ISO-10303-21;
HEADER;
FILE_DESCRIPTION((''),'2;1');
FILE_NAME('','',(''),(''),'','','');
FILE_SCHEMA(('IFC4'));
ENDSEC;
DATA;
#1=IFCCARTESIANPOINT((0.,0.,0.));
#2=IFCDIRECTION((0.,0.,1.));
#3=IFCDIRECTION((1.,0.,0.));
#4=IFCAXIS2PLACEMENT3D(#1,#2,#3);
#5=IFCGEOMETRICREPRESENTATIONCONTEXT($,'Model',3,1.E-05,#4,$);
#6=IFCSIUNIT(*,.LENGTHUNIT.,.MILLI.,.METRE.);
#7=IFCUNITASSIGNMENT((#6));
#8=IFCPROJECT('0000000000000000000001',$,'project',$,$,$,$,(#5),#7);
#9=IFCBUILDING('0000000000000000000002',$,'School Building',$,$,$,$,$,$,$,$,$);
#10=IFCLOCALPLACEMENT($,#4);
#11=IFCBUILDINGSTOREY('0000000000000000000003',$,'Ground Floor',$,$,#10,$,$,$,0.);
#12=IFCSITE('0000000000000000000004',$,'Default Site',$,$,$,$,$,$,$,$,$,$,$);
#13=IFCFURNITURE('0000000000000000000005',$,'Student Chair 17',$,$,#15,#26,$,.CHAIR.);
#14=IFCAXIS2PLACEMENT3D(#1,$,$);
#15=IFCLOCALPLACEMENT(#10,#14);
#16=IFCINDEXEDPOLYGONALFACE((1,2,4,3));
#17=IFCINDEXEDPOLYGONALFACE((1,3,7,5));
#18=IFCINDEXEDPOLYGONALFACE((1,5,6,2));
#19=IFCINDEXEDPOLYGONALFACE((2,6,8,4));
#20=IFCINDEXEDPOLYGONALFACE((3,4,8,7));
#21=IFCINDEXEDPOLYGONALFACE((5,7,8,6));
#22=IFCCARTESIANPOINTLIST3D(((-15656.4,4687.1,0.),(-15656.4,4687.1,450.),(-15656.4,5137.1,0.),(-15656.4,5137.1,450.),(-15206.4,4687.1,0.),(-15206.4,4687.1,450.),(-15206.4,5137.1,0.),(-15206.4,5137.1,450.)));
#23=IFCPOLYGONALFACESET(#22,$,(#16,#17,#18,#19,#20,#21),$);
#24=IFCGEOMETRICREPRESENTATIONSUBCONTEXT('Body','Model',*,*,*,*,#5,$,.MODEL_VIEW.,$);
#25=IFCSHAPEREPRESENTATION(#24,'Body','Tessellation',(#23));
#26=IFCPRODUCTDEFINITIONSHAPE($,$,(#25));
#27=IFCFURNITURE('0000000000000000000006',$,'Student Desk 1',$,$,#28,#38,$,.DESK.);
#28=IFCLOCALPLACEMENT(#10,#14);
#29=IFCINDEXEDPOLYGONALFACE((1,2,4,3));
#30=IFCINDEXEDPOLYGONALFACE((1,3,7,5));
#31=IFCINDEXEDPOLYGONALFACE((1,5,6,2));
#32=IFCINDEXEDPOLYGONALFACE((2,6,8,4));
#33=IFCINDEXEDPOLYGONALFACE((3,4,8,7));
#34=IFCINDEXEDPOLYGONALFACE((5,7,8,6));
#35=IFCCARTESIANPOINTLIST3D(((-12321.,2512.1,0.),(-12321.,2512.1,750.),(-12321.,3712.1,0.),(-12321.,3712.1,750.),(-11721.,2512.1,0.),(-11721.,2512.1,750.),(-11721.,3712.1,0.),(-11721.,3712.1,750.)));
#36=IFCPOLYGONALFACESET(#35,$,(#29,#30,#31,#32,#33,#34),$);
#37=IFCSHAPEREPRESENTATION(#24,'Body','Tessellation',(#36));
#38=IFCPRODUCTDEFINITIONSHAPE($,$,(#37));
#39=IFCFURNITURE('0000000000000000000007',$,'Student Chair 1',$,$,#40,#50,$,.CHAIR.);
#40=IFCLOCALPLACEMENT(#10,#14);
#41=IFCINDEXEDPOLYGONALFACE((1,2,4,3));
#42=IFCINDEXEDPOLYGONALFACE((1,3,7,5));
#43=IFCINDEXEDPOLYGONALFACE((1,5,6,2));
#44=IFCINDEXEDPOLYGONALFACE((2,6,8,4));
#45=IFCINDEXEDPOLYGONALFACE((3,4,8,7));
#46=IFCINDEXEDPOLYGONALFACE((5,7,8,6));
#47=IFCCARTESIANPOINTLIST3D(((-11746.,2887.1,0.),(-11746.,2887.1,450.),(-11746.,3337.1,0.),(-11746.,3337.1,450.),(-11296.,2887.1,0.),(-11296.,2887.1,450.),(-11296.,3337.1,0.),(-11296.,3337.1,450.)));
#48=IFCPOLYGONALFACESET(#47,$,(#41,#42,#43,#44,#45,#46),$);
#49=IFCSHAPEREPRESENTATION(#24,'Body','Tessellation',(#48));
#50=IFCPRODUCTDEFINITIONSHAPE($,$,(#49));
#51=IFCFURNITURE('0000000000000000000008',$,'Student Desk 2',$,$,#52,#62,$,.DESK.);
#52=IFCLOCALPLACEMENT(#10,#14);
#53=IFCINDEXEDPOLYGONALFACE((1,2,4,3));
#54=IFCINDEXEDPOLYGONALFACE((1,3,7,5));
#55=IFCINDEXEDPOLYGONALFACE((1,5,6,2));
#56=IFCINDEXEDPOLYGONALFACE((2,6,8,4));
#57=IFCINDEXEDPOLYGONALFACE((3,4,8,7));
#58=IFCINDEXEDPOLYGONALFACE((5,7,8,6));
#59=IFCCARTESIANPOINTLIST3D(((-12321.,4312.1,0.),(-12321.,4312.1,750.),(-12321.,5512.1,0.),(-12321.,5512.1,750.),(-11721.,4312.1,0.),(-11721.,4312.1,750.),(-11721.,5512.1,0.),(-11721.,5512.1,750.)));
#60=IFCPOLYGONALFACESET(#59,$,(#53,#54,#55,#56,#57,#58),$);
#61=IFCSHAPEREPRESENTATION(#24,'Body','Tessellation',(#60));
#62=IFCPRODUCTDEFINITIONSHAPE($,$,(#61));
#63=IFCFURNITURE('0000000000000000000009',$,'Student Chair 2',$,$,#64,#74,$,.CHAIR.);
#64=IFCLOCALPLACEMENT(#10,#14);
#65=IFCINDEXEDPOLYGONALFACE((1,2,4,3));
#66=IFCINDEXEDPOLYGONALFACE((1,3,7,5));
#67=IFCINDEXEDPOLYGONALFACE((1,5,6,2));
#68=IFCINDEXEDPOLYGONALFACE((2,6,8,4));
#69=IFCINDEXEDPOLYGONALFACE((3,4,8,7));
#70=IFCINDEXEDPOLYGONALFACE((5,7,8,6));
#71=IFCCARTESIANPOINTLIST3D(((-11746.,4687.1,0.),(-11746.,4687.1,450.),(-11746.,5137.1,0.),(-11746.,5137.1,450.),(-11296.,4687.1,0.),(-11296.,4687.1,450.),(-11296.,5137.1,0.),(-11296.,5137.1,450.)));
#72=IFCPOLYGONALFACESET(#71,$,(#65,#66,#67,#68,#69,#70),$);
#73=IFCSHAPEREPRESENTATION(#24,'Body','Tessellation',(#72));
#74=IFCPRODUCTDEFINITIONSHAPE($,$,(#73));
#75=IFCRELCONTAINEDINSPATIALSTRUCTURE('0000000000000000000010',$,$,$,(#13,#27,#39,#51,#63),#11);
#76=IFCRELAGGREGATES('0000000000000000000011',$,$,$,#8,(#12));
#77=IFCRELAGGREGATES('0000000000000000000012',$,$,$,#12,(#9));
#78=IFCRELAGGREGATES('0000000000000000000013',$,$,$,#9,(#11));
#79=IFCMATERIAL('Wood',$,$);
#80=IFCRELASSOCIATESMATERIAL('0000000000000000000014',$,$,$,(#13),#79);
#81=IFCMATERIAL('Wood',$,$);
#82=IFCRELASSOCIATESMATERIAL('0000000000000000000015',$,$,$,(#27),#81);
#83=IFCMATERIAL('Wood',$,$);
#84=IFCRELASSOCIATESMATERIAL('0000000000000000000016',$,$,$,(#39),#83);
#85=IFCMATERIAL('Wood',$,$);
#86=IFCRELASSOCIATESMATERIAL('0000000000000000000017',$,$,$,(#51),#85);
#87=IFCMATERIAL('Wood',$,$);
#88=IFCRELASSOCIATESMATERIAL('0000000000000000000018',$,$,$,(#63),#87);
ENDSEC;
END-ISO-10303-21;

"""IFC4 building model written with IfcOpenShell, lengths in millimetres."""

from ifc_helpers import new_model, si_unit, frame, origin_with_axes, origin_2d, place, context, subcontext, project, spatial, rectangle, extrude, material, element, save


model = new_model("IFC4")

# Units and contexts
model_context = context("Model", 3, precision=1e-05, world=origin_with_axes())
body_context = subcontext(model_context, "Body", "Model", "MODEL_VIEW")
ifc_project = project(units=[si_unit("LENGTHUNIT", "METRE", prefix="MILLI")], contexts=[model_context])

# Site, building, storey
site = spatial("IfcSite", under=ifc_project, Name="Default Site")
building = spatial("IfcBuilding", under=site, Name="School Building")
storey_placement = place(None, origin_with_axes())
storey = spatial("IfcBuildingStorey", under=building, at=storey_placement, Name="Ground Floor", Elevation=0.0)

# Furniture
ifc_material_1 = material(Name="Wood")
furniture_1_placement = place(storey_placement, frame((-15431.4, 4912.1, 0.0), z_axis=(0.0, 0.0, 1.0), x_axis=(1.0, 0.0, 0.0)))
element("IfcFurniture", 1, at=furniture_1_placement, inside=storey, material=ifc_material_1, Name="Student Chair 17", PredefinedType="CHAIR", context=body_context, shape_type="SweptSolid", body=[
    extrude(rectangle(XDim=450.0, YDim=450.0, at=origin_2d()), origin_with_axes(), (0.0, 0.0, 1.0), 450.0),
])
ifc_material_2 = material(Name="Wood")
furniture_2_placement = place(storey_placement, frame((-12021.0, 3112.1, 0.0), z_axis=(0.0, 0.0, 1.0), x_axis=(0.0, 1.0, 0.0)))
element("IfcFurniture", 2, at=furniture_2_placement, inside=storey, material=ifc_material_2, Name="Student Desk 1", PredefinedType="DESK", context=body_context, shape_type="SweptSolid", body=[
    extrude(rectangle(XDim=1200.0, YDim=600.0, at=origin_2d()), origin_with_axes(), (0.0, 0.0, 1.0), 750.0),
])
ifc_material_3 = material(Name="Wood")
furniture_3_placement = place(storey_placement, frame((-11521.0, 3112.1, 0.0), z_axis=(0.0, 0.0, 1.0), x_axis=(1.0, 0.0, 0.0)))
element("IfcFurniture", 3, at=furniture_3_placement, inside=storey, material=ifc_material_3, Name="Student Chair 1", PredefinedType="CHAIR", context=body_context, shape_type="SweptSolid", body=[
    extrude(rectangle(XDim=450.0, YDim=450.0, at=origin_2d()), origin_with_axes(), (0.0, 0.0, 1.0), 450.0),
])
ifc_material_4 = material(Name="Wood")
furniture_4_placement = place(storey_placement, frame((-12021.0, 4912.1, 0.0), z_axis=(0.0, 0.0, 1.0), x_axis=(0.0, 1.0, 0.0)))
element("IfcFurniture", 4, at=furniture_4_placement, inside=storey, material=ifc_material_4, Name="Student Desk 2", PredefinedType="DESK", context=body_context, shape_type="SweptSolid", body=[
    extrude(rectangle(XDim=1200.0, YDim=600.0, at=origin_2d()), origin_with_axes(), (0.0, 0.0, 1.0), 750.0),
])
ifc_material_5 = material(Name="Wood")
furniture_5_placement = place(storey_placement, frame((-11521.0, 4912.1, 0.0), z_axis=(0.0, 0.0, 1.0), x_axis=(1.0, 0.0, 0.0)))
element("IfcFurniture", 5, at=furniture_5_placement, inside=storey, material=ifc_material_5, Name="Student Chair 2", PredefinedType="CHAIR", context=body_context, shape_type="SweptSolid", body=[
    extrude(rectangle(XDim=450.0, YDim=450.0, at=origin_2d()), origin_with_axes(), (0.0, 0.0, 1.0), 450.0),
])

save(model, "model.ifc")
